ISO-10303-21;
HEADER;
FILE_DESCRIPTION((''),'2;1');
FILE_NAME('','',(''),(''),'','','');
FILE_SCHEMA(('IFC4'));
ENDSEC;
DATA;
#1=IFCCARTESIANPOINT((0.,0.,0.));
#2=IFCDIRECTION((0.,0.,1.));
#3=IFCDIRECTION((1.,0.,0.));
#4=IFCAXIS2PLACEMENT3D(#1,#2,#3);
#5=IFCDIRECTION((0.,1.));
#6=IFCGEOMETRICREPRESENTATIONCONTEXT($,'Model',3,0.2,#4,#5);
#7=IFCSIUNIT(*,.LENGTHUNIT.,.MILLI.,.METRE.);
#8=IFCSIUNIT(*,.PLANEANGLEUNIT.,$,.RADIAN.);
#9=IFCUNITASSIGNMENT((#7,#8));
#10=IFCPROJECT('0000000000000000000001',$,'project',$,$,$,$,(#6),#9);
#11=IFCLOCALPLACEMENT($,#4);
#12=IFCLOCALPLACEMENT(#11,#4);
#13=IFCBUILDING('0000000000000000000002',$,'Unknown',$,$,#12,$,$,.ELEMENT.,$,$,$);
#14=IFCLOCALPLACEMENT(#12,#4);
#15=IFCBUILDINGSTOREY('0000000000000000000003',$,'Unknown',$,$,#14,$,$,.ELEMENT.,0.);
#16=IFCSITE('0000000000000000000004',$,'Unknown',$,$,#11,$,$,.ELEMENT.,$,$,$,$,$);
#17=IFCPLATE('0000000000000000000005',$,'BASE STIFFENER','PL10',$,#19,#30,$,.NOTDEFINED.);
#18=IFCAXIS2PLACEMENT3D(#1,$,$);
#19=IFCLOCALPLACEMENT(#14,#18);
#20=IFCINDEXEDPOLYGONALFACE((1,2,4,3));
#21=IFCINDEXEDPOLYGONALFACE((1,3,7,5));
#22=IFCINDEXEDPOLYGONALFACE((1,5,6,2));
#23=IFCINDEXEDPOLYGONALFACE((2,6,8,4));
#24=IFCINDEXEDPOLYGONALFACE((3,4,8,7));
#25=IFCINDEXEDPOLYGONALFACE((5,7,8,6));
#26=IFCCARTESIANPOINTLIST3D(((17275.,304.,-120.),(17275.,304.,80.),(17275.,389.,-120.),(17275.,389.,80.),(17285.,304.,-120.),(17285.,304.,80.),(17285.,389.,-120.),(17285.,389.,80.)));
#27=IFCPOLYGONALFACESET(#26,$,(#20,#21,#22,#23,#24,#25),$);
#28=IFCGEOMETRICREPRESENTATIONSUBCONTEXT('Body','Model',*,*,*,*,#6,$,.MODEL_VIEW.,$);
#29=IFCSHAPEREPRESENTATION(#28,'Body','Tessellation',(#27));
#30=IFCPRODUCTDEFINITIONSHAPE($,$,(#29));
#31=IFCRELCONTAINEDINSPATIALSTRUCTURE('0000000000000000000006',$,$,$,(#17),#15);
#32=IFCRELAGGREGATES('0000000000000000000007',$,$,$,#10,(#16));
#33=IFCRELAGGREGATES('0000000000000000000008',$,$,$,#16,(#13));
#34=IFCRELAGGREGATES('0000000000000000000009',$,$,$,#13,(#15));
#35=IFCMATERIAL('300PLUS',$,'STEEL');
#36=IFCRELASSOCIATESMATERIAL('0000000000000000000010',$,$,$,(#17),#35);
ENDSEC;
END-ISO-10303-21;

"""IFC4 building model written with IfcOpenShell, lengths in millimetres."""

from ifc_helpers import new_model, si_unit, direction, frame, origin_with_axes, place, context, subcontext, project, spatial, line, indexed_curve, outline, extrude, material, element, save


model = new_model("IFC4")

# Units and contexts
model_context = context("Model", 3, precision=0.2, world=origin_with_axes(), true_north=direction((0.0, 1.0)))
body_context = subcontext(model_context, "Body", "Model", "MODEL_VIEW")
ifc_project = project(units=[si_unit("LENGTHUNIT", "METRE", prefix="MILLI"), si_unit("PLANEANGLEUNIT", "RADIAN")], contexts=[model_context])

# Site, building, storey
site_placement = place(None, origin_with_axes())
site = spatial("IfcSite", under=ifc_project, at=site_placement, Name="Unknown", CompositionType="ELEMENT")
building_placement = place(site_placement, origin_with_axes())
building = spatial("IfcBuilding", under=site, at=building_placement, Name="Unknown", CompositionType="ELEMENT")
storey_placement = place(building_placement, origin_with_axes())
storey = spatial("IfcBuildingStorey", under=building, at=storey_placement, Name="Unknown", CompositionType="ELEMENT", Elevation=0.0)

# Shared definitions
ifc_material_1 = material(Name="300PLUS", Category="STEEL")

# Plate
plate_1_placement = place(storey_placement, frame((17280.0, 304.0, -120.0), z_axis=(1.0, 0.0, 0.0), x_axis=(0.0, 1.0, 0.0)))
element("IfcPlate", 1, at=plate_1_placement, inside=storey, material=ifc_material_1, Name="BASE STIFFENER", Description="PL10", PredefinedType="NOTDEFINED", context=body_context, shape_type="SolidModel", body=[
    extrude(outline(indexed_curve([(0.0, 0.0), (85.0, 0.0), (85.0, 200.0), (0.0, 200.0)], segments=[line(1, 2, 3, 4, 1)])), frame((0.0, 0.0, 5.0), z_axis=(0.0, 0.0, 1.0), x_axis=(1.0, 0.0, 0.0)), (0.0, 0.0, -1.0), 10.0),
])

save(model, "model.ifc")
